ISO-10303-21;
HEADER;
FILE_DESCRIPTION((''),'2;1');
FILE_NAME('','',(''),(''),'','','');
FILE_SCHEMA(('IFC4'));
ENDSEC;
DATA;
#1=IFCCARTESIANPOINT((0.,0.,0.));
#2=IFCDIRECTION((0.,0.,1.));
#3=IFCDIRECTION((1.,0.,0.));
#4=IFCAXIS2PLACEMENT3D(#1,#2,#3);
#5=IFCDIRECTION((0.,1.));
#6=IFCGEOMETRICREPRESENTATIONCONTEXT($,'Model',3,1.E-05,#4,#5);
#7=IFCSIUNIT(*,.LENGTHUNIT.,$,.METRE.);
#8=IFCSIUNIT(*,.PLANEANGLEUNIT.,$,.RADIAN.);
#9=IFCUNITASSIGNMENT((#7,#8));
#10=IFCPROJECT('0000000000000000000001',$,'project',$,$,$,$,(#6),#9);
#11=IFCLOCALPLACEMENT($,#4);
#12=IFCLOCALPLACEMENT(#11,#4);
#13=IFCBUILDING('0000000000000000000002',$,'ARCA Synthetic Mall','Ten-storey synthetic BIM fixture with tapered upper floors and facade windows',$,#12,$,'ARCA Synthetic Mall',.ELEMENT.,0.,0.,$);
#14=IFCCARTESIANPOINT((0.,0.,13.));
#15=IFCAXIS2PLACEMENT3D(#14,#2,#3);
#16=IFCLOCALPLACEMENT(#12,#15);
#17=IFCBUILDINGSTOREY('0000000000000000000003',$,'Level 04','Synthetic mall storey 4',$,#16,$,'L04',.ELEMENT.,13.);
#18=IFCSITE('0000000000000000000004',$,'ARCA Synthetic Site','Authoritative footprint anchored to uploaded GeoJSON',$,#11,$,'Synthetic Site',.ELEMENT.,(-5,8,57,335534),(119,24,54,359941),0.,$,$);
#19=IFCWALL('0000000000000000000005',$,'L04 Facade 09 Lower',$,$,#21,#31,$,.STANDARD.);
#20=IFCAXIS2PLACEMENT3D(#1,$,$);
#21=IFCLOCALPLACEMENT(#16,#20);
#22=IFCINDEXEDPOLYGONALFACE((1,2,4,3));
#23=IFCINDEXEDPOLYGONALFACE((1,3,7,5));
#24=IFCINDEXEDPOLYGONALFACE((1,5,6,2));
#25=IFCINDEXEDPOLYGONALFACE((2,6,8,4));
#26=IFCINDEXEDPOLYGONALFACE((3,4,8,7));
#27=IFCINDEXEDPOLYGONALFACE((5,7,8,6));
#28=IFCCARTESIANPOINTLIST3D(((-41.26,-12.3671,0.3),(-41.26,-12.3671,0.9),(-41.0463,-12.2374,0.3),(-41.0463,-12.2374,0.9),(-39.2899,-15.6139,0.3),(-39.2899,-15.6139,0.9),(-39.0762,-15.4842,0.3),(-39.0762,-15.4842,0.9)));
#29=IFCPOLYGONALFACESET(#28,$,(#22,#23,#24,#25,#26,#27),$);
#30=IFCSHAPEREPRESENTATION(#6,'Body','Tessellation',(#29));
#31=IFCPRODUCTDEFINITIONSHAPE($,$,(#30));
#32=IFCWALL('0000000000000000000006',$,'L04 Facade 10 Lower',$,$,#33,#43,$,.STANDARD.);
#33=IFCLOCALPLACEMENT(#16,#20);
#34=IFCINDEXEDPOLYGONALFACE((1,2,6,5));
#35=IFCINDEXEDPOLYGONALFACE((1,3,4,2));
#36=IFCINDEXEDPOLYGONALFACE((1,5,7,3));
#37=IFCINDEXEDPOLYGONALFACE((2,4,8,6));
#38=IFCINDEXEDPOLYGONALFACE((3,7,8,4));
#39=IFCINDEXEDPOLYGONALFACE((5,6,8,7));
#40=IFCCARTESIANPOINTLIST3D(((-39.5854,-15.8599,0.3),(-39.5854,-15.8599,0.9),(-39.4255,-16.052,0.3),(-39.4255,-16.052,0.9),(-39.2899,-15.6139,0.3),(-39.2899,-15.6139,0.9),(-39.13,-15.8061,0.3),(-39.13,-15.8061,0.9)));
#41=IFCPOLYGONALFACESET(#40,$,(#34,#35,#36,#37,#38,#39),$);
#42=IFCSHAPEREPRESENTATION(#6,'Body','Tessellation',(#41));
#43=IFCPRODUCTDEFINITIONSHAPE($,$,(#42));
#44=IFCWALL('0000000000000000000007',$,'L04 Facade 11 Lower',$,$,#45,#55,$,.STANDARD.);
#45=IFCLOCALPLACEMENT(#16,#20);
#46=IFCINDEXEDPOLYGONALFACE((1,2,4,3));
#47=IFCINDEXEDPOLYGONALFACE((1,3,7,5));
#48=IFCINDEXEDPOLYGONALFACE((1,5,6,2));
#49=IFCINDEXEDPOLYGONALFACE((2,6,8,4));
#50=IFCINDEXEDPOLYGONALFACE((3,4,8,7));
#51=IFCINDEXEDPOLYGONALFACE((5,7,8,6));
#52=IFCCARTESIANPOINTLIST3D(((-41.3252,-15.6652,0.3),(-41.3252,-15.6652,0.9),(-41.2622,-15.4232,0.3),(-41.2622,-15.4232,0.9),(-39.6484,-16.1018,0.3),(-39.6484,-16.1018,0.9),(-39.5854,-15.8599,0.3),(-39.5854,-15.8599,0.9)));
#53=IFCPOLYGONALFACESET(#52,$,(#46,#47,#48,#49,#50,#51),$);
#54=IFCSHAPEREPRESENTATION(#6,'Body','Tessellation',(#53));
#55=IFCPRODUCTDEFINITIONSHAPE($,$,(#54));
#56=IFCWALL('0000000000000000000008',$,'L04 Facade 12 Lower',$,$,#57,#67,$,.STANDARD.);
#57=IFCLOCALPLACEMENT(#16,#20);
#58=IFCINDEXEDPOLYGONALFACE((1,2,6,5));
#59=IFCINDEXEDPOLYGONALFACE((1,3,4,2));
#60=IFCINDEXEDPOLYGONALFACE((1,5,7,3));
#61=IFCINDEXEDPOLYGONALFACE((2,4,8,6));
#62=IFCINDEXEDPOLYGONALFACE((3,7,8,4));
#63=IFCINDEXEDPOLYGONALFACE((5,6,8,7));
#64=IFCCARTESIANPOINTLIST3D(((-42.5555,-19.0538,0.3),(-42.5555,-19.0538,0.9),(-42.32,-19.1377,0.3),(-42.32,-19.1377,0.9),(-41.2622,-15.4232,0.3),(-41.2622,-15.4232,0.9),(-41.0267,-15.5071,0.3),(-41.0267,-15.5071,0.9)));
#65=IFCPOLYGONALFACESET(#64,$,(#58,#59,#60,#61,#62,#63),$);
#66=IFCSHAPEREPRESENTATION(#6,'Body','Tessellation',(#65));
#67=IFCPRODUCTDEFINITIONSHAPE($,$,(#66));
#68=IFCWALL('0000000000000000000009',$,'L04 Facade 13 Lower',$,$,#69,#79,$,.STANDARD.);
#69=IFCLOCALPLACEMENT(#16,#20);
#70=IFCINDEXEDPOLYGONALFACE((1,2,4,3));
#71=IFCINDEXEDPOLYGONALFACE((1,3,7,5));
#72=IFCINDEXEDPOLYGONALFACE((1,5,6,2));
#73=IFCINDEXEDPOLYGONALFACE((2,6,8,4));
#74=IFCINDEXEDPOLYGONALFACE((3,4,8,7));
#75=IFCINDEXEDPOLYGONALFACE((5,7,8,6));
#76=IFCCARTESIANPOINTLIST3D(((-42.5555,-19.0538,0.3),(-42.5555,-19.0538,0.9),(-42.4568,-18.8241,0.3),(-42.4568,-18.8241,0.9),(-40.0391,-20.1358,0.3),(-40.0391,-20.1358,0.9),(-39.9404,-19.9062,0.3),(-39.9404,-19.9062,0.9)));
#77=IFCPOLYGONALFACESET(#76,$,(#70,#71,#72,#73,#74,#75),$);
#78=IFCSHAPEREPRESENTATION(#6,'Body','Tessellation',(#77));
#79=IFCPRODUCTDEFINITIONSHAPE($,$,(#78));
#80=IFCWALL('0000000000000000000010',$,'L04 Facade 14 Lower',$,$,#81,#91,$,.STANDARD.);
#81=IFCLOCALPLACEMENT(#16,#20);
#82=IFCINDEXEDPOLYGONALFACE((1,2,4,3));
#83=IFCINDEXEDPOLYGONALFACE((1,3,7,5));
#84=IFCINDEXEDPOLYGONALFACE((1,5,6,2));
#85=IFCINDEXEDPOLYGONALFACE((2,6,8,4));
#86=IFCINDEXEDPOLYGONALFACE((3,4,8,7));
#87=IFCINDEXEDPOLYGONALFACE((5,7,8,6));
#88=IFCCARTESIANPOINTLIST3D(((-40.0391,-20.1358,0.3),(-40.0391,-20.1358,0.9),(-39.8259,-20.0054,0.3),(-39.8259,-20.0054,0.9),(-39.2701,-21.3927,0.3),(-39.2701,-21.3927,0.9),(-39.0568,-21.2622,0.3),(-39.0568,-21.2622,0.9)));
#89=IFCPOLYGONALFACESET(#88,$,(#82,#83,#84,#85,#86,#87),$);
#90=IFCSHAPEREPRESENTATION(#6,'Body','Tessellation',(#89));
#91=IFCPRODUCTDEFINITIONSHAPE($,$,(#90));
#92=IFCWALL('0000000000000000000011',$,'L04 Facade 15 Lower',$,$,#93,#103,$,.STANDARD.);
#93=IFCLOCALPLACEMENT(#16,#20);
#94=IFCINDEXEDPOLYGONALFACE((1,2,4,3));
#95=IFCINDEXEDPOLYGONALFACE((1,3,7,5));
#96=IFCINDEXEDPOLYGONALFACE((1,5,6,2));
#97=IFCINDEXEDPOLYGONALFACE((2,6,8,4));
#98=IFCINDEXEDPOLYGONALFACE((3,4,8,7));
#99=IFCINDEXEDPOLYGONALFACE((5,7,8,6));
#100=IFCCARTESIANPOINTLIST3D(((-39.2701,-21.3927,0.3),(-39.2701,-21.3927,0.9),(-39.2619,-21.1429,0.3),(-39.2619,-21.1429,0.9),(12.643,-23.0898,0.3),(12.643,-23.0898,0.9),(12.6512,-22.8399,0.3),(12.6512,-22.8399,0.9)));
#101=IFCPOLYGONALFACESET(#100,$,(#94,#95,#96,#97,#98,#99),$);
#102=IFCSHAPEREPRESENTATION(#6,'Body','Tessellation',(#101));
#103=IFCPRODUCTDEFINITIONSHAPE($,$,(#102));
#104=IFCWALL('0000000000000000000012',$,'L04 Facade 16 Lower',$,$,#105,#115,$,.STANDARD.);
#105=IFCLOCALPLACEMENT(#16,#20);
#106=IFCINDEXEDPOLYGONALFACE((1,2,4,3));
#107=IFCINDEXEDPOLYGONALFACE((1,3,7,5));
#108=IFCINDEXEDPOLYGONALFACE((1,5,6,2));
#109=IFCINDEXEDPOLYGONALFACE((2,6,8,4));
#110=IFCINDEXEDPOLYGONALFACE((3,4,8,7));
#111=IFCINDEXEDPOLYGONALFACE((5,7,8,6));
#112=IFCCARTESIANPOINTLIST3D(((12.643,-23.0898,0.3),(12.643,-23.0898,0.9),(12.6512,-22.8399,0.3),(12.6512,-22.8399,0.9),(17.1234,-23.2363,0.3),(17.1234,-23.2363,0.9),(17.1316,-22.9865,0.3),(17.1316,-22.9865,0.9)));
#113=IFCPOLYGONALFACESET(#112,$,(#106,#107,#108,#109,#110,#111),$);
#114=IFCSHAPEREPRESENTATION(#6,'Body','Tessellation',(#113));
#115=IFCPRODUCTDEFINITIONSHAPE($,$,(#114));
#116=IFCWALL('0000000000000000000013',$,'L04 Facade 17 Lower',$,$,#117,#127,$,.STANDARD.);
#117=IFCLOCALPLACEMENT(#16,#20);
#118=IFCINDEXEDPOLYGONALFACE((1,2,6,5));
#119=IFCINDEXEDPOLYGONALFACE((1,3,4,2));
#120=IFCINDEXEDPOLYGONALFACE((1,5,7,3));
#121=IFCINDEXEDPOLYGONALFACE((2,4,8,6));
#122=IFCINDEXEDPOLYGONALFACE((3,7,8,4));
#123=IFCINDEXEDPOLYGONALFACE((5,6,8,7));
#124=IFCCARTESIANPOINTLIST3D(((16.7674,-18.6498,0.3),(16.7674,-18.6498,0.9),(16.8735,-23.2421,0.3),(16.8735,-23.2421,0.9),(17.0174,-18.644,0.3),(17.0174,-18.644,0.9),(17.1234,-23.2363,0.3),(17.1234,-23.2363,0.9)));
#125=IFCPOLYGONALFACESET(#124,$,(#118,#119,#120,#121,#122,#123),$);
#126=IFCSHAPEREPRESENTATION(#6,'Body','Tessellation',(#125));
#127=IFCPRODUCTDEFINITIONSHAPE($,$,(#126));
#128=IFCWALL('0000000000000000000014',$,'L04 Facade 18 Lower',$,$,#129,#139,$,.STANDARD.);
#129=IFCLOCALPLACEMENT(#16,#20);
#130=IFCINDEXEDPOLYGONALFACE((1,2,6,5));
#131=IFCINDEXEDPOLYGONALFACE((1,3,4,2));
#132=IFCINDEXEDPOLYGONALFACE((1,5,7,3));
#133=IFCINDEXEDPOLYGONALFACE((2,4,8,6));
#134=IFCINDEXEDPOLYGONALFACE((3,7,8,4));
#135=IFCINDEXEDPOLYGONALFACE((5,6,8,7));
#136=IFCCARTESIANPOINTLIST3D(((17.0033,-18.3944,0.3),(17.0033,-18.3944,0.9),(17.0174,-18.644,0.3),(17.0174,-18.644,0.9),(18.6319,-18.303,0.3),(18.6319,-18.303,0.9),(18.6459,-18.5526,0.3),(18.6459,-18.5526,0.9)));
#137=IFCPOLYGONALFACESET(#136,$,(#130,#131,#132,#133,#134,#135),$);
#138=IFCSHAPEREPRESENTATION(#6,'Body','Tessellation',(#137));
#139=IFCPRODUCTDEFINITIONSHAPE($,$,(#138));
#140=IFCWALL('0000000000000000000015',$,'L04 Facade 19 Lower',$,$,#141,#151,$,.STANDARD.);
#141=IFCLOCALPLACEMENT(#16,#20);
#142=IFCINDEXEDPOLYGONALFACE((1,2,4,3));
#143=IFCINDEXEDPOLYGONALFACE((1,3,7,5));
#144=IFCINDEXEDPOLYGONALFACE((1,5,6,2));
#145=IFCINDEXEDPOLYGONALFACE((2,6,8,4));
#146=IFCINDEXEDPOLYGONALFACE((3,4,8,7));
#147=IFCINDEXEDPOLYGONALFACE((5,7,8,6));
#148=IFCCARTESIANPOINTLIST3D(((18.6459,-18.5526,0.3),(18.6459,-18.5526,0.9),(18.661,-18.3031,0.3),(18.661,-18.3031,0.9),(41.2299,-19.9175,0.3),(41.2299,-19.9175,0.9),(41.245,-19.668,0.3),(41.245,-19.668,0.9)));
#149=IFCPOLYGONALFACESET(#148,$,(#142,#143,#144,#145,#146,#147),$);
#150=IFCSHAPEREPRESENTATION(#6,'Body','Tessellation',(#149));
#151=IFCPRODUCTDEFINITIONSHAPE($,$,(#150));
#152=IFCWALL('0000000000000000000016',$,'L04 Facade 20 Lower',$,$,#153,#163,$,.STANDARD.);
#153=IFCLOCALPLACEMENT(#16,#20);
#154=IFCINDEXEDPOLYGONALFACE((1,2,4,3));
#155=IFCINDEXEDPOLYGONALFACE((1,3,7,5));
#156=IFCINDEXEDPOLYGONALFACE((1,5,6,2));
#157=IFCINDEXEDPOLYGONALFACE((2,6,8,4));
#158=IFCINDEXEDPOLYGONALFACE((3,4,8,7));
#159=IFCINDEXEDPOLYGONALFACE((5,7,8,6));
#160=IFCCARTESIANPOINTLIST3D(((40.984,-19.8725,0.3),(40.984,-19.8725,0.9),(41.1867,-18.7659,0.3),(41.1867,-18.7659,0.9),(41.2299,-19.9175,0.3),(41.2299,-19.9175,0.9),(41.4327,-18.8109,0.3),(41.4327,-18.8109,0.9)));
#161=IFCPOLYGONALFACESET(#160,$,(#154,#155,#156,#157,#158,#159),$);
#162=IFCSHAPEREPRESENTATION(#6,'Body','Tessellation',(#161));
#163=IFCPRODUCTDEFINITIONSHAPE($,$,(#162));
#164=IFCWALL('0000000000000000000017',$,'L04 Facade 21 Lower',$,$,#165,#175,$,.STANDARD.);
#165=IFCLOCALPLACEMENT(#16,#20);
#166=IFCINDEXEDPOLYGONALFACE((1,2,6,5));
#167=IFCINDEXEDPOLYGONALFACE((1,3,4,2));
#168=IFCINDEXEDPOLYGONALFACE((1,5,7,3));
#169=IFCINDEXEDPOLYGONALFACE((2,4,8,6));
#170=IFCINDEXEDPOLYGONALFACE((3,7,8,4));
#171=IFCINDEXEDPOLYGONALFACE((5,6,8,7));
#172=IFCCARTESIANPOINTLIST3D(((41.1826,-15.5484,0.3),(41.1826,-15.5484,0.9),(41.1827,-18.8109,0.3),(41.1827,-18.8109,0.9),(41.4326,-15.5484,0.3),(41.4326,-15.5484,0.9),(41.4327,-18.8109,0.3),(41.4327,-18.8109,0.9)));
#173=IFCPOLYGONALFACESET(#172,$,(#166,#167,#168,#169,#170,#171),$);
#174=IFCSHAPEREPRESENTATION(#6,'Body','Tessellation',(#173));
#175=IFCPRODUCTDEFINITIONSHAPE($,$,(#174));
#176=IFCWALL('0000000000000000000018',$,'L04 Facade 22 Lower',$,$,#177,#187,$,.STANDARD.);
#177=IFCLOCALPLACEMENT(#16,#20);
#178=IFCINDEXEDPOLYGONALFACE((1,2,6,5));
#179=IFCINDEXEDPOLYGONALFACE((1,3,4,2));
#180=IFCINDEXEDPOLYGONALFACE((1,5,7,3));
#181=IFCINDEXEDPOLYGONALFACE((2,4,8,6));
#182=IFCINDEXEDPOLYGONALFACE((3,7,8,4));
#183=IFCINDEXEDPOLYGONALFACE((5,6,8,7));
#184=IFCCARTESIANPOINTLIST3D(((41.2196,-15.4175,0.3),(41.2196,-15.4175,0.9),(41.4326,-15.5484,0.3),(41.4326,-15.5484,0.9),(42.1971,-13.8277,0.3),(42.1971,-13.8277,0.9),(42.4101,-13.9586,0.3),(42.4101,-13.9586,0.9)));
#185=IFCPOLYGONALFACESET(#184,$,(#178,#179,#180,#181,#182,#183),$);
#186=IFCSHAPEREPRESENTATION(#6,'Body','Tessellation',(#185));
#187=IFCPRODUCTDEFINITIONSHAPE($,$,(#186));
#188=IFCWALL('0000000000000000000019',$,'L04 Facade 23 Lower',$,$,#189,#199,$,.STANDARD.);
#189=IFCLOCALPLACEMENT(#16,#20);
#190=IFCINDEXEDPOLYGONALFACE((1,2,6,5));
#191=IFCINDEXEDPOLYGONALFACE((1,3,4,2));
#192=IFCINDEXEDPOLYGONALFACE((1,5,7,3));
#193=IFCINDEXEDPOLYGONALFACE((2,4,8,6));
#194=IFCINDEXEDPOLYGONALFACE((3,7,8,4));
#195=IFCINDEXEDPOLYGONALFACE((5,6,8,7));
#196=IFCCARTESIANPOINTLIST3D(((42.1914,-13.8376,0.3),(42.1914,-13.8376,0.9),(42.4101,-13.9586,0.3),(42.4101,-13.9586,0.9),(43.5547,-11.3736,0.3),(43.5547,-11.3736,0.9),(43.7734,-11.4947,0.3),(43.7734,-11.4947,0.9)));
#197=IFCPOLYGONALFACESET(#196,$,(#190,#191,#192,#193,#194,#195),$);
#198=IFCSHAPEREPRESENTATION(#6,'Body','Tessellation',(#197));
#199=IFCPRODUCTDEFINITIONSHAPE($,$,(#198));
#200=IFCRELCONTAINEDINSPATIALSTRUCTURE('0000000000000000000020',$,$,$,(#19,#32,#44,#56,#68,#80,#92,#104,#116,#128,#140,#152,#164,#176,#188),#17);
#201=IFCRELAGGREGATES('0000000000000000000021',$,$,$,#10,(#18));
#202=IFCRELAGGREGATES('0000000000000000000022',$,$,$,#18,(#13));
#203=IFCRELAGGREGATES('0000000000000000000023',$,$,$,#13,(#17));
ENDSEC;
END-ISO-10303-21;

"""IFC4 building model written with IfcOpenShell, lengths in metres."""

from ifc_helpers import new_model, si_unit, direction, frame, origin_with_axes, place, context, project, spatial, polyline, outline, extrude, element, save


model = new_model("IFC4")

# Units and contexts
model_context = context("Model", 3, precision=1e-05, world=origin_with_axes(), true_north=direction((0.0, 1.0)))
ifc_project = project(units=[si_unit("LENGTHUNIT", "METRE"), si_unit("PLANEANGLEUNIT", "RADIAN")], contexts=[model_context])

# Site, building, storey
site_placement = place(None, origin_with_axes())
site = spatial("IfcSite", under=ifc_project, at=site_placement, Name="ARCA Synthetic Site", Description="Authoritative footprint anchored to uploaded GeoJSON", LongName="Synthetic Site", CompositionType="ELEMENT", RefLatitude=(-5, 8, 57, 335534), RefLongitude=(119, 24, 54, 359941), RefElevation=0.0)
building_placement = place(site_placement, origin_with_axes())
building = spatial("IfcBuilding", under=site, at=building_placement, Name="ARCA Synthetic Mall", Description="Ten-storey synthetic BIM fixture with tapered upper floors and facade windows", LongName="ARCA Synthetic Mall", CompositionType="ELEMENT", ElevationOfRefHeight=0.0, ElevationOfTerrain=0.0)
storey_placement = place(building_placement, frame((0.0, 0.0, 13.0), z_axis=(0.0, 0.0, 1.0), x_axis=(1.0, 0.0, 0.0)))
storey = spatial("IfcBuildingStorey", under=building, at=storey_placement, Name="Level 04", Description="Synthetic mall storey 4", LongName="L04", CompositionType="ELEMENT", Elevation=13.0)

# Walls
wall_1_placement = place(storey_placement, frame((0.0, 0.0, 0.3), z_axis=(0.0, 0.0, 1.0), x_axis=(1.0, 0.0, 0.0)))
element("IfcWall", 1, at=wall_1_placement, inside=storey, Name="L04 Facade 09 Lower", PredefinedType="STANDARD", context=model_context, shape_type="SweptSolid", body=[
    extrude(outline(polyline([(-41.26, -12.3671), (-39.2899, -15.6139), (-39.0762, -15.4842), (-41.0463, -12.2374), (-41.26, -12.3671)])), origin_with_axes(), (0.0, 0.0, 1.0), 0.6),
])
wall_2_placement = place(storey_placement, frame((0.0, 0.0, 0.3), z_axis=(0.0, 0.0, 1.0), x_axis=(1.0, 0.0, 0.0)))
element("IfcWall", 2, at=wall_2_placement, inside=storey, Name="L04 Facade 10 Lower", PredefinedType="STANDARD", context=model_context, shape_type="SweptSolid", body=[
    extrude(outline(polyline([(-39.2899, -15.6139), (-39.5854, -15.8599), (-39.4255, -16.052), (-39.13, -15.8061), (-39.2899, -15.6139)])), origin_with_axes(), (0.0, 0.0, 1.0), 0.6),
])
wall_3_placement = place(storey_placement, frame((0.0, 0.0, 0.3), z_axis=(0.0, 0.0, 1.0), x_axis=(1.0, 0.0, 0.0)))
element("IfcWall", 3, at=wall_3_placement, inside=storey, Name="L04 Facade 11 Lower", PredefinedType="STANDARD", context=model_context, shape_type="SweptSolid", body=[
    extrude(outline(polyline([(-39.5854, -15.8599), (-41.2622, -15.4232), (-41.3252, -15.6652), (-39.6484, -16.1018), (-39.5854, -15.8599)])), origin_with_axes(), (0.0, 0.0, 1.0), 0.6),
])
wall_4_placement = place(storey_placement, frame((0.0, 0.0, 0.3), z_axis=(0.0, 0.0, 1.0), x_axis=(1.0, 0.0, 0.0)))
element("IfcWall", 4, at=wall_4_placement, inside=storey, Name="L04 Facade 12 Lower", PredefinedType="STANDARD", context=model_context, shape_type="SweptSolid", body=[
    extrude(outline(polyline([(-41.2622, -15.4232), (-42.5555, -19.0538), (-42.32, -19.1377), (-41.0267, -15.5071), (-41.2622, -15.4232)])), origin_with_axes(), (0.0, 0.0, 1.0), 0.6),
])
wall_5_placement = place(storey_placement, frame((0.0, 0.0, 0.3), z_axis=(0.0, 0.0, 1.0), x_axis=(1.0, 0.0, 0.0)))
element("IfcWall", 5, at=wall_5_placement, inside=storey, Name="L04 Facade 13 Lower", PredefinedType="STANDARD", context=model_context, shape_type="SweptSolid", body=[
    extrude(outline(polyline([(-42.5555, -19.0538), (-40.0391, -20.1358), (-39.9404, -19.9062), (-42.4568, -18.8241), (-42.5555, -19.0538)])), origin_with_axes(), (0.0, 0.0, 1.0), 0.6),
])
wall_6_placement = place(storey_placement, frame((0.0, 0.0, 0.3), z_axis=(0.0, 0.0, 1.0), x_axis=(1.0, 0.0, 0.0)))
element("IfcWall", 6, at=wall_6_placement, inside=storey, Name="L04 Facade 14 Lower", PredefinedType="STANDARD", context=model_context, shape_type="SweptSolid", body=[
    extrude(outline(polyline([(-40.0391, -20.1358), (-39.2701, -21.3927), (-39.0568, -21.2622), (-39.8259, -20.0054), (-40.0391, -20.1358)])), origin_with_axes(), (0.0, 0.0, 1.0), 0.6),
])
wall_7_placement = place(storey_placement, frame((0.0, 0.0, 0.3), z_axis=(0.0, 0.0, 1.0), x_axis=(1.0, 0.0, 0.0)))
element("IfcWall", 7, at=wall_7_placement, inside=storey, Name="L04 Facade 15 Lower", PredefinedType="STANDARD", context=model_context, shape_type="SweptSolid", body=[
    extrude(outline(polyline([(-39.2701, -21.3927), (12.6431, -23.0898), (12.6512, -22.8399), (-39.2619, -21.1429), (-39.2701, -21.3927)])), origin_with_axes(), (0.0, 0.0, 1.0), 0.6),
])
wall_8_placement = place(storey_placement, frame((0.0, 0.0, 0.3), z_axis=(0.0, 0.0, 1.0), x_axis=(1.0, 0.0, 0.0)))
element("IfcWall", 8, at=wall_8_placement, inside=storey, Name="L04 Facade 16 Lower", PredefinedType="STANDARD", context=model_context, shape_type="SweptSolid", body=[
    extrude(outline(polyline([(12.6431, -23.0898), (17.1234, -23.2363), (17.1316, -22.9865), (12.6512, -22.8399), (12.6431, -23.0898)])), origin_with_axes(), (0.0, 0.0, 1.0), 0.6),
])
wall_9_placement = place(storey_placement, frame((0.0, 0.0, 0.3), z_axis=(0.0, 0.0, 1.0), x_axis=(1.0, 0.0, 0.0)))
element("IfcWall", 9, at=wall_9_placement, inside=storey, Name="L04 Facade 17 Lower", PredefinedType="STANDARD", context=model_context, shape_type="SweptSolid", body=[
    extrude(outline(polyline([(17.1234, -23.2363), (17.0174, -18.644), (16.7674, -18.6498), (16.8735, -23.2421), (17.1234, -23.2363)])), origin_with_axes(), (0.0, 0.0, 1.0), 0.6),
])
wall_10_placement = place(storey_placement, frame((0.0, 0.0, 0.3), z_axis=(0.0, 0.0, 1.0), x_axis=(1.0, 0.0, 0.0)))
element("IfcWall", 10, at=wall_10_placement, inside=storey, Name="L04 Facade 18 Lower", PredefinedType="STANDARD", context=model_context, shape_type="SweptSolid", body=[
    extrude(outline(polyline([(17.0174, -18.644), (18.6459, -18.5526), (18.6319, -18.303), (17.0033, -18.3944), (17.0174, -18.644)])), origin_with_axes(), (0.0, 0.0, 1.0), 0.6),
])
wall_11_placement = place(storey_placement, frame((0.0, 0.0, 0.3), z_axis=(0.0, 0.0, 1.0), x_axis=(1.0, 0.0, 0.0)))
element("IfcWall", 11, at=wall_11_placement, inside=storey, Name="L04 Facade 19 Lower", PredefinedType="STANDARD", context=model_context, shape_type="SweptSolid", body=[
    extrude(outline(polyline([(18.6459, -18.5526), (41.2299, -19.9175), (41.245, -19.668), (18.661, -18.3031), (18.6459, -18.5526)])), origin_with_axes(), (0.0, 0.0, 1.0), 0.6),
])
wall_12_placement = place(storey_placement, frame((0.0, 0.0, 0.3), z_axis=(0.0, 0.0, 1.0), x_axis=(1.0, 0.0, 0.0)))
element("IfcWall", 12, at=wall_12_placement, inside=storey, Name="L04 Facade 20 Lower", PredefinedType="STANDARD", context=model_context, shape_type="SweptSolid", body=[
    extrude(outline(polyline([(41.2299, -19.9175), (41.4327, -18.8109), (41.1867, -18.7659), (40.984, -19.8725), (41.2299, -19.9175)])), origin_with_axes(), (0.0, 0.0, 1.0), 0.6),
])
wall_13_placement = place(storey_placement, frame((0.0, 0.0, 0.3), z_axis=(0.0, 0.0, 1.0), x_axis=(1.0, 0.0, 0.0)))
element("IfcWall", 13, at=wall_13_placement, inside=storey, Name="L04 Facade 21 Lower", PredefinedType="STANDARD", context=model_context, shape_type="SweptSolid", body=[
    extrude(outline(polyline([(41.4327, -18.8109), (41.4326, -15.5484), (41.1826, -15.5484), (41.1827, -18.8109), (41.4327, -18.8109)])), origin_with_axes(), (0.0, 0.0, 1.0), 0.6),
])
wall_14_placement = place(storey_placement, frame((0.0, 0.0, 0.3), z_axis=(0.0, 0.0, 1.0), x_axis=(1.0, 0.0, 0.0)))
element("IfcWall", 14, at=wall_14_placement, inside=storey, Name="L04 Facade 22 Lower", PredefinedType="STANDARD", context=model_context, shape_type="SweptSolid", body=[
    extrude(outline(polyline([(41.4326, -15.5484), (42.4101, -13.9586), (42.1971, -13.8277), (41.2196, -15.4175), (41.4326, -15.5484)])), origin_with_axes(), (0.0, 0.0, 1.0), 0.6),
])
wall_15_placement = place(storey_placement, frame((0.0, 0.0, 0.3), z_axis=(0.0, 0.0, 1.0), x_axis=(1.0, 0.0, 0.0)))
element("IfcWall", 15, at=wall_15_placement, inside=storey, Name="L04 Facade 23 Lower", PredefinedType="STANDARD", context=model_context, shape_type="SweptSolid", body=[
    extrude(outline(polyline([(42.4101, -13.9586), (43.7734, -11.4947), (43.5547, -11.3736), (42.1914, -13.8376), (42.4101, -13.9586)])), origin_with_axes(), (0.0, 0.0, 1.0), 0.6),
])

save(model, "model.ifc")
